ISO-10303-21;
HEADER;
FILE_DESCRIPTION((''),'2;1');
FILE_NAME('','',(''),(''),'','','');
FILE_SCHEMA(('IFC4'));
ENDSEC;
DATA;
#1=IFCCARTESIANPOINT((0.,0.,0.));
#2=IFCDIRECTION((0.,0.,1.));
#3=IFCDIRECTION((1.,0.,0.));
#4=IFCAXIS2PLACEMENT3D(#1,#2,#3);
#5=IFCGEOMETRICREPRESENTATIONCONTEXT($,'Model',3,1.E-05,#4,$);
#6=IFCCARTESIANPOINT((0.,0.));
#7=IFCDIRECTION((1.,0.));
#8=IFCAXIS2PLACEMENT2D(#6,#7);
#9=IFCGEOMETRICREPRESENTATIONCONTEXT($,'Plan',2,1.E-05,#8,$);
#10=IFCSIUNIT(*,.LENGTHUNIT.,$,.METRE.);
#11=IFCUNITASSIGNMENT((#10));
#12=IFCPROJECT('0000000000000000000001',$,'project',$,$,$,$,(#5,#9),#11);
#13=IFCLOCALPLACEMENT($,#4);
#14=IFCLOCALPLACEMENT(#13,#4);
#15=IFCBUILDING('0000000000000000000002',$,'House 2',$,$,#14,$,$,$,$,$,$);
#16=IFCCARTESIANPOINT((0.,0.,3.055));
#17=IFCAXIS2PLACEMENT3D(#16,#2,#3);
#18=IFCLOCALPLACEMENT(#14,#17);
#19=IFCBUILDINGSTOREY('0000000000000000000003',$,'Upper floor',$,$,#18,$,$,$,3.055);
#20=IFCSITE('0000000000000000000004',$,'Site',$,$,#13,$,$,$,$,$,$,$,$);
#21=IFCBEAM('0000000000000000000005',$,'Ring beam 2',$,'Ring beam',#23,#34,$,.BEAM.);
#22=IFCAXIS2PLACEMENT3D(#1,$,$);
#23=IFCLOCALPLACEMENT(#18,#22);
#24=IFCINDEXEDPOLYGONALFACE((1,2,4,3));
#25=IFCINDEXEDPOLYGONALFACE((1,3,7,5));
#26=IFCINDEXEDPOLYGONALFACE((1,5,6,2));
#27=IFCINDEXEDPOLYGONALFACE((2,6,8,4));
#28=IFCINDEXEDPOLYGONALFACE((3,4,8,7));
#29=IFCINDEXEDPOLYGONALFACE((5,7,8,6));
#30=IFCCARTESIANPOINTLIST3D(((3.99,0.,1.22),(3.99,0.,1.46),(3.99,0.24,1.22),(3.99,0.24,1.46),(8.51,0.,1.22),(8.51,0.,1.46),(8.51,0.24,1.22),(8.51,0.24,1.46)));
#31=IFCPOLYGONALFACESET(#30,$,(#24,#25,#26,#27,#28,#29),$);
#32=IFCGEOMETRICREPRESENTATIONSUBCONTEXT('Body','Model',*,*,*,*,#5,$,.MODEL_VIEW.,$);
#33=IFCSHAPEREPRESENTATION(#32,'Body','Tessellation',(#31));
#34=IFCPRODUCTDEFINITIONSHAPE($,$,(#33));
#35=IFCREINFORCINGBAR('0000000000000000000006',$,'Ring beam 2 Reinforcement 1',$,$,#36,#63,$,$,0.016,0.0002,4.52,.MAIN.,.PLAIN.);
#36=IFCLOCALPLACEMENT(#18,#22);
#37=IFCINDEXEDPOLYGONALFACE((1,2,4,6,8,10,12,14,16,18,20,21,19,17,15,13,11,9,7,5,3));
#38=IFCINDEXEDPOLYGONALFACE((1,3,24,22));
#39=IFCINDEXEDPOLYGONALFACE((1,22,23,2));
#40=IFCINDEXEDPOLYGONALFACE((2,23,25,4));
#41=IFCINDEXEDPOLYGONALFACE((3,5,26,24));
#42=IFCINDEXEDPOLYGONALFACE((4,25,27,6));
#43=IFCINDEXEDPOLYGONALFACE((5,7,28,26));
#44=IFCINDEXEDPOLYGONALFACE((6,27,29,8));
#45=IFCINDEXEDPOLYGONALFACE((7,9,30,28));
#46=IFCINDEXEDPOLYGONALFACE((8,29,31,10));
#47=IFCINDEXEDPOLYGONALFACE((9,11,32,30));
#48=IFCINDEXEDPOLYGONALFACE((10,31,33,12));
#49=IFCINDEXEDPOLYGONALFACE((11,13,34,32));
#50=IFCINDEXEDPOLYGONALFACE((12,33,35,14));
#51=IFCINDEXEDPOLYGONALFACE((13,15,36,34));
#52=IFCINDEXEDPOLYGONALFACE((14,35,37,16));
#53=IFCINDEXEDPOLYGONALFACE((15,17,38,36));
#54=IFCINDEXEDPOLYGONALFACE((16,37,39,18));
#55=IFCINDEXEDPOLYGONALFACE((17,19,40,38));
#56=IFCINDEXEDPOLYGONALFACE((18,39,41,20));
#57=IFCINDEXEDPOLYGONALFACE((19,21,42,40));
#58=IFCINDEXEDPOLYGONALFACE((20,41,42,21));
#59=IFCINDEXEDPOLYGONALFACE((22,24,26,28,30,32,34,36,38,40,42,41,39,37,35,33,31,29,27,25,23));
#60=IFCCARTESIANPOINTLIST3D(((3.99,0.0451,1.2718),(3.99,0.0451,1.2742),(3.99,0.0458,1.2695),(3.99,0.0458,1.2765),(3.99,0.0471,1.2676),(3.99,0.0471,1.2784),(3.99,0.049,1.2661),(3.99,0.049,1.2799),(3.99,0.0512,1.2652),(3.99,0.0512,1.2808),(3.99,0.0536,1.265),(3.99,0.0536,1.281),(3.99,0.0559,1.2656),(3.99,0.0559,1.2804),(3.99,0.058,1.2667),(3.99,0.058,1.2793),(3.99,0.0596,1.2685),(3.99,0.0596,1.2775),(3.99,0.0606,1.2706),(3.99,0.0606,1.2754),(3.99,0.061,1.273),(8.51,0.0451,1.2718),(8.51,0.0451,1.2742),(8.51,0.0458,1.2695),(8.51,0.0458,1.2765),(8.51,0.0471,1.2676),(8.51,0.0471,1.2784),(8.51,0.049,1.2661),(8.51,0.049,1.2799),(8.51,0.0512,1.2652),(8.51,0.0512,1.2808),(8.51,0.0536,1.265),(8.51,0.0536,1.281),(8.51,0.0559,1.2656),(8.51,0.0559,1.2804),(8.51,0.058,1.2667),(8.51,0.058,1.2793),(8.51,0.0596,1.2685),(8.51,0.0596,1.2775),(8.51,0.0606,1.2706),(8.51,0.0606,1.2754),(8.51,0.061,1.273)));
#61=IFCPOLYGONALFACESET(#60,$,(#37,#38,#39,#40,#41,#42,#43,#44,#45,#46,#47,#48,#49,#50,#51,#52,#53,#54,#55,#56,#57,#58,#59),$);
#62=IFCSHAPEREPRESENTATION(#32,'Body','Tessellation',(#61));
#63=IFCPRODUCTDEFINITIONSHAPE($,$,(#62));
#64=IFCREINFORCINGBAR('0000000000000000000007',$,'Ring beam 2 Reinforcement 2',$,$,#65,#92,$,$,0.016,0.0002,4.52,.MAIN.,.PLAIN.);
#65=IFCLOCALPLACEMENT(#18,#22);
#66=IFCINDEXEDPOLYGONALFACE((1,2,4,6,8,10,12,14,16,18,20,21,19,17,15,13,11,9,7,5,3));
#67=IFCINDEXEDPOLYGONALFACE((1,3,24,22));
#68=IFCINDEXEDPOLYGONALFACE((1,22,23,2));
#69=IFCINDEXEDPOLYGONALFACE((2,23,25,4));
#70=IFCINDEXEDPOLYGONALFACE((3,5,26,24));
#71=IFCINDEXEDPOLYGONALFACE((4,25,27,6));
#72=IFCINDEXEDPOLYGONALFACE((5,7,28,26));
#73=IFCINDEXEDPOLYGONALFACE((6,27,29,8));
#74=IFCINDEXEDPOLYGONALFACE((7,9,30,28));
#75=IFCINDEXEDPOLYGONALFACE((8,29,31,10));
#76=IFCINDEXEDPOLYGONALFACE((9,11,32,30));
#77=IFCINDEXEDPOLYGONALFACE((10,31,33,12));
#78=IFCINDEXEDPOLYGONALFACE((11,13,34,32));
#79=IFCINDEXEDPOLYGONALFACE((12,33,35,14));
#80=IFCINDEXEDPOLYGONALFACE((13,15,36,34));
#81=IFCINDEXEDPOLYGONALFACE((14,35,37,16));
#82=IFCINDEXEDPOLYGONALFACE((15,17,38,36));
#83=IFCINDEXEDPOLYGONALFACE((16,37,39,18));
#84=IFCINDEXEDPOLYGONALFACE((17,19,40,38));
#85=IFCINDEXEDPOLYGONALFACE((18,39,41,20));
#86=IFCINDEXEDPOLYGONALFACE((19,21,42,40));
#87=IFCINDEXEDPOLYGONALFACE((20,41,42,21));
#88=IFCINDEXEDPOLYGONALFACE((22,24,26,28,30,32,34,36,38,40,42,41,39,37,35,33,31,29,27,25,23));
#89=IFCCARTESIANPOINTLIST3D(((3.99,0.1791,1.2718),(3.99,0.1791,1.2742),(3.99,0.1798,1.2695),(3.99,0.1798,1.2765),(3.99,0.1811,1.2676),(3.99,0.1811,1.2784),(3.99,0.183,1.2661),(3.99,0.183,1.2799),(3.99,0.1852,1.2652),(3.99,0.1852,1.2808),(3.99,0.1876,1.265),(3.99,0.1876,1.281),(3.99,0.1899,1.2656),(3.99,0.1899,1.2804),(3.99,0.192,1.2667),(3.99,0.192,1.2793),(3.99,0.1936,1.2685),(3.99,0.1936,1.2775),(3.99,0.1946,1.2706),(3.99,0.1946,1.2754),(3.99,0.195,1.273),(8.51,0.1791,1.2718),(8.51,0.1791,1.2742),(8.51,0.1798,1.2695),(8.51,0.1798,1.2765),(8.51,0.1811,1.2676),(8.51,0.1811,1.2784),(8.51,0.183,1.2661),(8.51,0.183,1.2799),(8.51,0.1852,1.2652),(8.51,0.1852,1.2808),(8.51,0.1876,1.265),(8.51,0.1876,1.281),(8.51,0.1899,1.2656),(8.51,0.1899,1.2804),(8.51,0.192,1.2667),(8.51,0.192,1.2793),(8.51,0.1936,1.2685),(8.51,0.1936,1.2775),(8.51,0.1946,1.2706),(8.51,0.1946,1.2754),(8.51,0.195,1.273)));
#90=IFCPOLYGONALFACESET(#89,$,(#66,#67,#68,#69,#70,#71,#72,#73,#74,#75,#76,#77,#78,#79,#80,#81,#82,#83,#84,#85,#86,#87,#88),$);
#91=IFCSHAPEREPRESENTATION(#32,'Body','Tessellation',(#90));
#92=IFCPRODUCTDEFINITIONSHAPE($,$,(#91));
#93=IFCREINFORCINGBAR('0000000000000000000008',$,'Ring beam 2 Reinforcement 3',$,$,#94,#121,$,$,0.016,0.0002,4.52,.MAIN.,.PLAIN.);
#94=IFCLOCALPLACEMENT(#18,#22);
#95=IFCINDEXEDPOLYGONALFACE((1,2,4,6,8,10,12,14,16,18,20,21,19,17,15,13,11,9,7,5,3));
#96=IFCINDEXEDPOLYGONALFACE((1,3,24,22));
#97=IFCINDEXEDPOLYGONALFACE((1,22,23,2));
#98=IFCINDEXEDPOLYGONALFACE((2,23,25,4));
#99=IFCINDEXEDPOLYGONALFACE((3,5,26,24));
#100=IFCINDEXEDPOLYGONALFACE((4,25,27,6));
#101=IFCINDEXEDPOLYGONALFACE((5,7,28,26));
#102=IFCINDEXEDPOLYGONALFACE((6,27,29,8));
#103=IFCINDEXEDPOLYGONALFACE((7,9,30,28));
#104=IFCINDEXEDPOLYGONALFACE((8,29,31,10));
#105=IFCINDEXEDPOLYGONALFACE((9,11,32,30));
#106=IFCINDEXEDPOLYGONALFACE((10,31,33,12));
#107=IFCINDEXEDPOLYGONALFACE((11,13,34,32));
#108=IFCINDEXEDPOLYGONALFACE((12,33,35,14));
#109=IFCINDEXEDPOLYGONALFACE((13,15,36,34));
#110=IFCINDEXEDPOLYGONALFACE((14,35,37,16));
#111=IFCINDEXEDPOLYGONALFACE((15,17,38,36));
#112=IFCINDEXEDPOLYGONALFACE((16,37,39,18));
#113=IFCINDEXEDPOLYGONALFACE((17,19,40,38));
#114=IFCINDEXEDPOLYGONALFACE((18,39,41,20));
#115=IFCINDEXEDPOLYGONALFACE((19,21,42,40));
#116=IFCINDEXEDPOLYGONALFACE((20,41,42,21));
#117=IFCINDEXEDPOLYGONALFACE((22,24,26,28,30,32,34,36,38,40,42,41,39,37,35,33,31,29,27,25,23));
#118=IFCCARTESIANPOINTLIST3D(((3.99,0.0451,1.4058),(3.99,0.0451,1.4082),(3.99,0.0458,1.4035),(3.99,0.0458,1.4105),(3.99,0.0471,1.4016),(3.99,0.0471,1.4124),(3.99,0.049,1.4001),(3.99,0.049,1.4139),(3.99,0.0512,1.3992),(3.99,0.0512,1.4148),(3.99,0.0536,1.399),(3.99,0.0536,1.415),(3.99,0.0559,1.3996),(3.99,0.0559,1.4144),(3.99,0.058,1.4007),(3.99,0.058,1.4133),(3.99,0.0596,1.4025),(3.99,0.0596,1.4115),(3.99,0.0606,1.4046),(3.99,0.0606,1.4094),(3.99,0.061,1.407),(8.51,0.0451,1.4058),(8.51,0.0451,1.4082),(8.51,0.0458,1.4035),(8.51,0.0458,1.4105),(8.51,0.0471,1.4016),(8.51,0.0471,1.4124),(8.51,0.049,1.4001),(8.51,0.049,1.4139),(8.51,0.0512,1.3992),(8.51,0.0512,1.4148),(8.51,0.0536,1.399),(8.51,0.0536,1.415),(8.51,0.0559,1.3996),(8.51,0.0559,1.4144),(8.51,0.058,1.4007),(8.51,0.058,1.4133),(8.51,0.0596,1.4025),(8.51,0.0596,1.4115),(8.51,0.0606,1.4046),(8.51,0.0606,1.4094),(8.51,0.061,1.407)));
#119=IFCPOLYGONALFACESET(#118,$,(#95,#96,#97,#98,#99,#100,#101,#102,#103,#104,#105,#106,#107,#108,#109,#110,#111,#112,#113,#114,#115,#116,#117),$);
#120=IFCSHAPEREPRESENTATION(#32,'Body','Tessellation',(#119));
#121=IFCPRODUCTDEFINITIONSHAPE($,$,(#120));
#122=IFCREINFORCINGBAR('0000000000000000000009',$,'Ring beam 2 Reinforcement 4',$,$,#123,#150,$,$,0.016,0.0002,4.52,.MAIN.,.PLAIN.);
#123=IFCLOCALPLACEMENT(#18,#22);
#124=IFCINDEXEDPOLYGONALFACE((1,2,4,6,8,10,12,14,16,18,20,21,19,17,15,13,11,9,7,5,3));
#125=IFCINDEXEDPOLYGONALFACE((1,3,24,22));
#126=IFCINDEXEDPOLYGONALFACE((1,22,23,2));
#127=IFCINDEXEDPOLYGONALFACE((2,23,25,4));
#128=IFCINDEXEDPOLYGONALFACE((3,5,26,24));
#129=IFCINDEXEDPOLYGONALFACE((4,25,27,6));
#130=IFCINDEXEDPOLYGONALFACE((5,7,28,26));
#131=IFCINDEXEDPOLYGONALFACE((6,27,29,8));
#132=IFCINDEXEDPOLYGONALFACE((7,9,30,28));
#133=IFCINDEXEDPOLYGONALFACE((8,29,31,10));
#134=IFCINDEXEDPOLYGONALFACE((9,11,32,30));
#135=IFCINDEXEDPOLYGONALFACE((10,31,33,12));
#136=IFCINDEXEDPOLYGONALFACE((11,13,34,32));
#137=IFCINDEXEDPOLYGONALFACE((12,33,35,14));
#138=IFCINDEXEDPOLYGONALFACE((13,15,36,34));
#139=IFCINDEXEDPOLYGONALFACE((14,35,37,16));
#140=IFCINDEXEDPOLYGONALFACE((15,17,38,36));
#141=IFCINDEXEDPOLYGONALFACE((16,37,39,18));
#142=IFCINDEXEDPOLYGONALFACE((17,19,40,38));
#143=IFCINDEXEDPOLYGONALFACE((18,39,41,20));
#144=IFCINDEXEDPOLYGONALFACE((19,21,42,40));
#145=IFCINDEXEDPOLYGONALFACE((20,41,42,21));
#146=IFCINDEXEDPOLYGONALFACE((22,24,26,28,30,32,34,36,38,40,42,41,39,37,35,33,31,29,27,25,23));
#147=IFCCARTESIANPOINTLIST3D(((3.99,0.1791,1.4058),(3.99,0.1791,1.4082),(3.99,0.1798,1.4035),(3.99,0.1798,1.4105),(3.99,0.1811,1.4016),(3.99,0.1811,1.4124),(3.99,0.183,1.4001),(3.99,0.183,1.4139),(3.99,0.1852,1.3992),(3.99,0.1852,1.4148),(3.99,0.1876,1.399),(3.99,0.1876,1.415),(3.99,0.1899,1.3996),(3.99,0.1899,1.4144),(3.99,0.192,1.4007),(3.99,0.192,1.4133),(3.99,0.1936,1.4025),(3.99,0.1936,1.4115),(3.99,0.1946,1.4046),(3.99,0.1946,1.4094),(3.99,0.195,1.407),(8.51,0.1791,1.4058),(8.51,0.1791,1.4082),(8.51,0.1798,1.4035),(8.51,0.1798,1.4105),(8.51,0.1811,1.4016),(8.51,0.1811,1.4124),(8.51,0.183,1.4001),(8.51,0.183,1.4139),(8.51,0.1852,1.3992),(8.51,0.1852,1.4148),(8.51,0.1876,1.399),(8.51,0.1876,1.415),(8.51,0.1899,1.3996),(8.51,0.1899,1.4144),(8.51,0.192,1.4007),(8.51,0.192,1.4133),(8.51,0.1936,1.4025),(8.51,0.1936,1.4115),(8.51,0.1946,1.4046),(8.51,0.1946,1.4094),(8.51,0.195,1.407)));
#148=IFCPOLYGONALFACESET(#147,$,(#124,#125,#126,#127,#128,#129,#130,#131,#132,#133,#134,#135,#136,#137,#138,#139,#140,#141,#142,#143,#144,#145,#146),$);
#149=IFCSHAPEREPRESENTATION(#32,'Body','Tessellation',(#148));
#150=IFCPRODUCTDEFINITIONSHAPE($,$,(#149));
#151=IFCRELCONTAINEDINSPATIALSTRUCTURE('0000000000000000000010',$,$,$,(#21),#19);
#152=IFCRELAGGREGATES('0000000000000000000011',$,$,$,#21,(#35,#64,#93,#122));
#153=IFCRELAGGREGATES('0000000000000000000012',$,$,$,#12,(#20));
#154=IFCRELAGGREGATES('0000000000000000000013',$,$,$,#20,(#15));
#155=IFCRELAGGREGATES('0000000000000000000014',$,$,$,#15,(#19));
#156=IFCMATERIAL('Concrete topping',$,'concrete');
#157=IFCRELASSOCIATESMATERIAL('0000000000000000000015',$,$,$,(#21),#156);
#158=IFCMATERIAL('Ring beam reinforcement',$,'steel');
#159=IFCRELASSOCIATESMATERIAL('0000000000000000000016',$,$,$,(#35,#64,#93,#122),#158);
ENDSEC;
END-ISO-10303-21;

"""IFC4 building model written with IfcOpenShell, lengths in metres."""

from ifc_helpers import new_model, si_unit, frame, origin_with_axes, origin_2d, origin_2d_with_axis, place, context, subcontext, project, spatial, circle_curve, rectangle, outline, extrude, material, element, aggregate, save


model = new_model("IFC4")

# Units and contexts
model_context = context("Model", 3, precision=1e-05, world=origin_with_axes())
plan_context = context("Plan", 2, precision=1e-05, world=origin_2d_with_axis())
body_context_1 = subcontext(model_context, "Body", "Model", "MODEL_VIEW")
ifc_project = project(units=[si_unit("LENGTHUNIT", "METRE")], contexts=[model_context, plan_context])

# Site, building, storey
site_placement = place(None, origin_with_axes())
site = spatial("IfcSite", under=ifc_project, at=site_placement, Name="Site")
building_placement = place(site_placement, origin_with_axes())
building = spatial("IfcBuilding", under=site, at=building_placement, Name="House 2")
storey_placement = place(building_placement, frame((0.0, 0.0, 3.055), z_axis=(0.0, 0.0, 1.0), x_axis=(1.0, 0.0, 0.0)))
storey = spatial("IfcBuildingStorey", under=building, at=storey_placement, Name="Upper floor", Elevation=3.055)

# Beam
ifc_material_1 = material(Name="Concrete topping", Category="concrete")
beam_1_placement = place(storey_placement, frame((3.99, 0.12, 1.34), z_axis=(0.0, 0.0, 1.0), x_axis=(1.0, 0.0, 0.0)))
beam_1 = element("IfcBeam", 1, at=beam_1_placement, inside=storey, material=ifc_material_1, Name="Ring beam 2", ObjectType="Ring beam", PredefinedType="BEAM", context=body_context_1, shape_type="SweptSolid", body=[
    extrude(rectangle(XDim=0.24, YDim=0.24), frame((0.0, 0.0, 0.0), z_axis=(1.0, 0.0, 0.0), x_axis=(0.0, 1.0, 0.0)), (0.0, 0.0, 1.0), 4.52),
])

# Reinforcing bars
ifc_material_2 = material(Name="Ring beam reinforcement", Category="steel")
reinforcing_bar_1_placement = place(beam_1_placement, frame((0.0, -0.067, -0.067), z_axis=(0.0, 0.0, 1.0), x_axis=(1.0, 0.0, 0.0)))
reinforcing_bar_1 = element("IfcReinforcingBar", 2, at=reinforcing_bar_1_placement, material=ifc_material_2, Name="Ring beam 2 Reinforcement 1", BarLength=4.52, BarSurface="PLAIN", CrossSectionArea=0.0002, NominalDiameter=0.016, PredefinedType="MAIN", context=body_context_1, shape_type="SweptSolid", body=[
    extrude(outline(circle_curve(origin_2d(), 0.008)), frame((0.0, 0.0, 0.0), z_axis=(1.0, 0.0, 0.0), x_axis=(0.0, 1.0, 0.0)), (0.0, 0.0, 1.0), 4.52),
])
reinforcing_bar_2_placement = place(beam_1_placement, frame((0.0, 0.067, -0.067), z_axis=(0.0, 0.0, 1.0), x_axis=(1.0, 0.0, 0.0)))
reinforcing_bar_2 = element("IfcReinforcingBar", 3, at=reinforcing_bar_2_placement, material=ifc_material_2, Name="Ring beam 2 Reinforcement 2", BarLength=4.52, BarSurface="PLAIN", CrossSectionArea=0.0002, NominalDiameter=0.016, PredefinedType="MAIN", context=body_context_1, shape_type="SweptSolid", body=[
    extrude(outline(circle_curve(origin_2d(), 0.008)), frame((0.0, 0.0, 0.0), z_axis=(1.0, 0.0, 0.0), x_axis=(0.0, 1.0, 0.0)), (0.0, 0.0, 1.0), 4.52),
])
reinforcing_bar_3_placement = place(beam_1_placement, frame((0.0, -0.067, 0.067), z_axis=(0.0, 0.0, 1.0), x_axis=(1.0, 0.0, 0.0)))
reinforcing_bar_3 = element("IfcReinforcingBar", 4, at=reinforcing_bar_3_placement, material=ifc_material_2, Name="Ring beam 2 Reinforcement 3", BarLength=4.52, BarSurface="PLAIN", CrossSectionArea=0.0002, NominalDiameter=0.016, PredefinedType="MAIN", context=body_context_1, shape_type="SweptSolid", body=[
    extrude(outline(circle_curve(origin_2d(), 0.008)), frame((0.0, 0.0, 0.0), z_axis=(1.0, 0.0, 0.0), x_axis=(0.0, 1.0, 0.0)), (0.0, 0.0, 1.0), 4.52),
])
reinforcing_bar_4_placement = place(beam_1_placement, frame((0.0, 0.067, 0.067), z_axis=(0.0, 0.0, 1.0), x_axis=(1.0, 0.0, 0.0)))
reinforcing_bar_4 = element("IfcReinforcingBar", 5, at=reinforcing_bar_4_placement, material=ifc_material_2, Name="Ring beam 2 Reinforcement 4", BarLength=4.52, BarSurface="PLAIN", CrossSectionArea=0.0002, NominalDiameter=0.016, PredefinedType="MAIN", context=body_context_1, shape_type="SweptSolid", body=[
    extrude(outline(circle_curve(origin_2d(), 0.008)), frame((0.0, 0.0, 0.0), z_axis=(1.0, 0.0, 0.0), x_axis=(0.0, 1.0, 0.0)), (0.0, 0.0, 1.0), 4.52),
])
aggregate(beam_1, [reinforcing_bar_1, reinforcing_bar_2, reinforcing_bar_3, reinforcing_bar_4])

save(model, "model.ifc")
